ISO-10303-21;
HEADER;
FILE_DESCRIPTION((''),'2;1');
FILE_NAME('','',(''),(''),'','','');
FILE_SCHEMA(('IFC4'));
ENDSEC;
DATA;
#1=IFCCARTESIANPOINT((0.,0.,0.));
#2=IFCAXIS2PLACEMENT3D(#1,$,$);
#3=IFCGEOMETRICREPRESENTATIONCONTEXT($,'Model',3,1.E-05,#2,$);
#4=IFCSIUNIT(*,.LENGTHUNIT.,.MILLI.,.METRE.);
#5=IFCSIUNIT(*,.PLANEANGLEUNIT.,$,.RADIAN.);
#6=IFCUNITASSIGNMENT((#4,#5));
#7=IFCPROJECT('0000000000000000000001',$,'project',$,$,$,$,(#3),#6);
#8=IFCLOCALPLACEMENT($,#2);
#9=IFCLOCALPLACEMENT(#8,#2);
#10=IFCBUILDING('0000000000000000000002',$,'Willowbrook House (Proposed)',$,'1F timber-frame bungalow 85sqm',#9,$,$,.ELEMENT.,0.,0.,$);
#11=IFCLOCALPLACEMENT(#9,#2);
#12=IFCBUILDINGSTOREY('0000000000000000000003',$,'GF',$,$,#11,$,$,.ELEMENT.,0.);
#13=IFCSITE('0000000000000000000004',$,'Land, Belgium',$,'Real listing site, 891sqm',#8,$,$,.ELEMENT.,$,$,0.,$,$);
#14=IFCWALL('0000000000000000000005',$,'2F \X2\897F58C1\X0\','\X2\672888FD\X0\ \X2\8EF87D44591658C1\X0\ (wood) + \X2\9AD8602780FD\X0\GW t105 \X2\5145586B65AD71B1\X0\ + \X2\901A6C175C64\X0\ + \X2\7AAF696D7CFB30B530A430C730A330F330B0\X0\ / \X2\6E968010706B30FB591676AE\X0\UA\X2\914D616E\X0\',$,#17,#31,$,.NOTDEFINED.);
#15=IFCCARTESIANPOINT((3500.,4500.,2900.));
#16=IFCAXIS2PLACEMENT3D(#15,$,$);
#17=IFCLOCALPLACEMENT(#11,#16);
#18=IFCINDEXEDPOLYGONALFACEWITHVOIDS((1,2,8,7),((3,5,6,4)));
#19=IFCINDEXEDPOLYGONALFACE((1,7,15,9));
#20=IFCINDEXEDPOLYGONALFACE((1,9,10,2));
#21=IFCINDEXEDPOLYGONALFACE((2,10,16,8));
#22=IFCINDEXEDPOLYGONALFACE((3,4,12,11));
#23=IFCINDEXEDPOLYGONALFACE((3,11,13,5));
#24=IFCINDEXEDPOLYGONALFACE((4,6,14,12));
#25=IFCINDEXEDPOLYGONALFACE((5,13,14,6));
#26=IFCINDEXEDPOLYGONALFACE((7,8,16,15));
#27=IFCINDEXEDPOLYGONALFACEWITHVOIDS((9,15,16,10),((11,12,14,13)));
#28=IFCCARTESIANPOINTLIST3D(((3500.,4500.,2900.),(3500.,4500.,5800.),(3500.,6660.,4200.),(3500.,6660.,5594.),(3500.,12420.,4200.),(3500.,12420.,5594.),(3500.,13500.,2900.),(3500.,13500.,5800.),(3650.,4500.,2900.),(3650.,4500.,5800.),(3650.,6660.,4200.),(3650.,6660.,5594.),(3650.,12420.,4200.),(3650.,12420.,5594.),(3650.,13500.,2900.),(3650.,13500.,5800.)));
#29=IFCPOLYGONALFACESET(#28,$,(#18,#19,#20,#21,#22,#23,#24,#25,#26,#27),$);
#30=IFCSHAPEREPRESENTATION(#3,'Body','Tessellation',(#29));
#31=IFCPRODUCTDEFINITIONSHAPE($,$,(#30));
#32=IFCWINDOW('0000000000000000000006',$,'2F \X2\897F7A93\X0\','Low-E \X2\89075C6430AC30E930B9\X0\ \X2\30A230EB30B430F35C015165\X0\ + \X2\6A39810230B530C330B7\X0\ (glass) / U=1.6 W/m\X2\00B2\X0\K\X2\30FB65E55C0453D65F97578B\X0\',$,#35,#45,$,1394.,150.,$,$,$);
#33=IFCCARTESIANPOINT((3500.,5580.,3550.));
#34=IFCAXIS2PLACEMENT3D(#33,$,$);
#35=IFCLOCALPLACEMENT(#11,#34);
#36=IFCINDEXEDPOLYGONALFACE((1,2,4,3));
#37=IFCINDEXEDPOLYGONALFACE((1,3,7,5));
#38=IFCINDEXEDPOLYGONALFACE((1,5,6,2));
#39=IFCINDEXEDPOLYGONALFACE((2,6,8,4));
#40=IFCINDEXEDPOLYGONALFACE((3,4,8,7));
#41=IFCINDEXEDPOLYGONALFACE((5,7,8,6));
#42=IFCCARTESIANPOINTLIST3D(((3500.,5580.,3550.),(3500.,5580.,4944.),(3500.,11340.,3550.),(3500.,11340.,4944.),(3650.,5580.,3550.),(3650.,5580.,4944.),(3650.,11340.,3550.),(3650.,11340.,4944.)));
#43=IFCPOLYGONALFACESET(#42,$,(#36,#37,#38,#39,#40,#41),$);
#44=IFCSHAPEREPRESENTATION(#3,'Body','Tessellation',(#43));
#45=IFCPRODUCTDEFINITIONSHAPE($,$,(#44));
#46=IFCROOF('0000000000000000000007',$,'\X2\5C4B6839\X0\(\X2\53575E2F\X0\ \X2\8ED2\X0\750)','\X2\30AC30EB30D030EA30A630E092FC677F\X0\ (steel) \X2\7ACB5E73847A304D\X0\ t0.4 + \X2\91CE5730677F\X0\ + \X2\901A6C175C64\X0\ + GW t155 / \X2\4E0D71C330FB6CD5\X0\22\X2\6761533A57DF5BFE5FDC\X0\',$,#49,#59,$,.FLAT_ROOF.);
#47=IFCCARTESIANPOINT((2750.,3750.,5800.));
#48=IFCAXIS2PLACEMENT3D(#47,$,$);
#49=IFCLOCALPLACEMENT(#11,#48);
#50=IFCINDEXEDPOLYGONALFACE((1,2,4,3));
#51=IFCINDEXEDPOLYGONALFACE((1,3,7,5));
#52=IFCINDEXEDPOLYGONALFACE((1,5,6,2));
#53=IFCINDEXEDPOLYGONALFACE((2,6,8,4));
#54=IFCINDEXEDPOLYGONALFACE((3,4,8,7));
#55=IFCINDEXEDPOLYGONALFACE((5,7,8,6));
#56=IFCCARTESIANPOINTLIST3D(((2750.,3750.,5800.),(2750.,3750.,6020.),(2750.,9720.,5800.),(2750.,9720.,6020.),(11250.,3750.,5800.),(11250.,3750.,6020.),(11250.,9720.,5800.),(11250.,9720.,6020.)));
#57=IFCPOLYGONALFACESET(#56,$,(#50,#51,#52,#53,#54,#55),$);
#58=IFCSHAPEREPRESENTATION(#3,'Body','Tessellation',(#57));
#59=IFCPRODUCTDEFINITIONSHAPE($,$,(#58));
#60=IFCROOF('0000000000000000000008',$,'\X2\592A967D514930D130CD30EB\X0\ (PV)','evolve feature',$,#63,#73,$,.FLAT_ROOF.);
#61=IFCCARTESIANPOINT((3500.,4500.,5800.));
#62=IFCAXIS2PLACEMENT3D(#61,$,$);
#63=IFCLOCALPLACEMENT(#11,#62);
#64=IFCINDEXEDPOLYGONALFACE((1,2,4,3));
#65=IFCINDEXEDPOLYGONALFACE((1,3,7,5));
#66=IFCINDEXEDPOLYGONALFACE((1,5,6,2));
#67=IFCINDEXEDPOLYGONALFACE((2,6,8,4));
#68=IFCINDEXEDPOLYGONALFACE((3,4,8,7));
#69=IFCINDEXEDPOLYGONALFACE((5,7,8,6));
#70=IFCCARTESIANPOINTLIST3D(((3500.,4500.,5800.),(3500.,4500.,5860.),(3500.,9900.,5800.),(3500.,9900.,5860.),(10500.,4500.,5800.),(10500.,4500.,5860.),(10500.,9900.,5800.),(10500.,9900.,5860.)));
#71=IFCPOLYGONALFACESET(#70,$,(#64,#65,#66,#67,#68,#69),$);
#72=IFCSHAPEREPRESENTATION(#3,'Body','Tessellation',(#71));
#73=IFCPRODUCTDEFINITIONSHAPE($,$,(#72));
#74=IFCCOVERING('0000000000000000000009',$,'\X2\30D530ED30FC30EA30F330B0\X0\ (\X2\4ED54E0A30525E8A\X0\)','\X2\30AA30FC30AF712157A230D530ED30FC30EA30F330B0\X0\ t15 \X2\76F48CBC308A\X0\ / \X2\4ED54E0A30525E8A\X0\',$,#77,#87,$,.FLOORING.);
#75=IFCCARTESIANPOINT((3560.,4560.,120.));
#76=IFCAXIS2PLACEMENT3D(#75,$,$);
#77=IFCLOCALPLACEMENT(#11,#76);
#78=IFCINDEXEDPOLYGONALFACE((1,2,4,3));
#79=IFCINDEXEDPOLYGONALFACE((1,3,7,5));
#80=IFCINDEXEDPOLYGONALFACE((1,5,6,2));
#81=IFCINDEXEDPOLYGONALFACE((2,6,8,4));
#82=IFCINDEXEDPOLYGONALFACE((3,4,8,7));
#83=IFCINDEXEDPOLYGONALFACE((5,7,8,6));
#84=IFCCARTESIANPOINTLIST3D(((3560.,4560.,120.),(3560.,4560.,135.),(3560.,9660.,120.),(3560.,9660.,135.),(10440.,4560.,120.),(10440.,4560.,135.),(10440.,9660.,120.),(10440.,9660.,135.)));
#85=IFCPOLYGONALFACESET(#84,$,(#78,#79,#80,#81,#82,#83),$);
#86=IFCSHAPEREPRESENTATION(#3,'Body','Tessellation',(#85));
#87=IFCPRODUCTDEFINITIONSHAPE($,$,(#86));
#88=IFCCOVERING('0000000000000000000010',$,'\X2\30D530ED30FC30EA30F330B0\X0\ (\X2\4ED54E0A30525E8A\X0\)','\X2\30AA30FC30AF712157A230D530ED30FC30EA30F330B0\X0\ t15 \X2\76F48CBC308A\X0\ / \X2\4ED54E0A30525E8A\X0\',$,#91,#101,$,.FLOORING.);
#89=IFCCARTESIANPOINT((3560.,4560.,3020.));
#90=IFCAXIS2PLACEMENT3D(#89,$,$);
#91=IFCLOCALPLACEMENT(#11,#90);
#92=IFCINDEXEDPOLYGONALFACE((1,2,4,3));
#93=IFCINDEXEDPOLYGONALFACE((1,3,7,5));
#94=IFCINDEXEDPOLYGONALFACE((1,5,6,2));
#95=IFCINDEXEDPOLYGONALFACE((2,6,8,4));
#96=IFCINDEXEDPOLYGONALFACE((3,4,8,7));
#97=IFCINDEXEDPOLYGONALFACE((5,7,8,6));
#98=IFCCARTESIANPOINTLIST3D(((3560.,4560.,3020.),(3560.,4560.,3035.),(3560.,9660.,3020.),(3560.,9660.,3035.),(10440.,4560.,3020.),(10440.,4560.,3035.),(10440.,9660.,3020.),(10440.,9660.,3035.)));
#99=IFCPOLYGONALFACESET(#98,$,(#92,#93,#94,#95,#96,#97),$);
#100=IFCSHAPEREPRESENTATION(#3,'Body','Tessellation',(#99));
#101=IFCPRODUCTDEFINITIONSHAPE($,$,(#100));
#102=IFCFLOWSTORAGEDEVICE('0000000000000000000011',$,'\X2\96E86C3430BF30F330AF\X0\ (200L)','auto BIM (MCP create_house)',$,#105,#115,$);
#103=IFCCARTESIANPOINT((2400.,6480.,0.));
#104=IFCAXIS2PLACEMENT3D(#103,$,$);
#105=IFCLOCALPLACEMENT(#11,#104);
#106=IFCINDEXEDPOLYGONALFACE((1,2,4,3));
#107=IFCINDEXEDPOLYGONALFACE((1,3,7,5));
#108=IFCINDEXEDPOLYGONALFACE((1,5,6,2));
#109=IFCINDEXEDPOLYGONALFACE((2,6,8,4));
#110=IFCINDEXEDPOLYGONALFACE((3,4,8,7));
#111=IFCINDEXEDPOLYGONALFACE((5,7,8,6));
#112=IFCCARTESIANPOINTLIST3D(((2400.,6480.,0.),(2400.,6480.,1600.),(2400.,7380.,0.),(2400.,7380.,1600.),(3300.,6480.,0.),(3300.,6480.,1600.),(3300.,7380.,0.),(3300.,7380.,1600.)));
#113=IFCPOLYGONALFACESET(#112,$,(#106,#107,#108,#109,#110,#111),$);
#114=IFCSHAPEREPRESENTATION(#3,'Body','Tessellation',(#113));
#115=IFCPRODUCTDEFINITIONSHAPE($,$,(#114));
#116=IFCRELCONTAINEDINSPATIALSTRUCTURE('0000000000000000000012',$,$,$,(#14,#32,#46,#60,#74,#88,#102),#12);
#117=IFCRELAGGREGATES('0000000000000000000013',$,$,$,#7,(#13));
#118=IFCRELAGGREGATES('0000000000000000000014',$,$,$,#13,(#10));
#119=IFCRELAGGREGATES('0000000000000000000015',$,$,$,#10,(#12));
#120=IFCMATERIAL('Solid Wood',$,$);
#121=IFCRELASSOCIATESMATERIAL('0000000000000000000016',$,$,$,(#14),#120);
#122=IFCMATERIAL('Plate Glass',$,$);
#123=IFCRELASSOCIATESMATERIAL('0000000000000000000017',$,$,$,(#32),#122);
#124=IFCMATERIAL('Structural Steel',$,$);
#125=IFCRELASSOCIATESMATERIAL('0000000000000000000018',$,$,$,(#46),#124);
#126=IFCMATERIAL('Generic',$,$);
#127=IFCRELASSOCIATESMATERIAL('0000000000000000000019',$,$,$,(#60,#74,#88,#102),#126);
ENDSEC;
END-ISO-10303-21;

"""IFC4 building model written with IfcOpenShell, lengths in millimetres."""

from ifc_helpers import new_model, si_unit, frame, frame_2d, origin, place, context, project, spatial, rectangle, extrude, material, element, fill, save


model = new_model("IFC4")

# Units and contexts
model_context = context("Model", 3, precision=1e-05, world=origin())
ifc_project = project(units=[si_unit("LENGTHUNIT", "METRE", prefix="MILLI"), si_unit("PLANEANGLEUNIT", "RADIAN")], contexts=[model_context])

# Site, building, storey
site_placement = place(None, origin())
site = spatial("IfcSite", under=ifc_project, at=site_placement, Name="Land, Belgium", ObjectType="Real listing site, 891sqm", CompositionType="ELEMENT", RefElevation=0.0)
building_placement = place(site_placement, origin())
building = spatial("IfcBuilding", under=site, at=building_placement, Name="Willowbrook House (Proposed)", ObjectType="1F timber-frame bungalow 85sqm", CompositionType="ELEMENT", ElevationOfRefHeight=0.0, ElevationOfTerrain=0.0)
storey_placement = place(building_placement, origin())
storey = spatial("IfcBuildingStorey", under=building, at=storey_placement, Name="GF", CompositionType="ELEMENT", Elevation=0.0)

# Shared definitions
ifc_material_1 = material(Name="Solid Wood")
ifc_material_2 = material(Name="Generic")

# Shared definitions
ifc_material_3 = material(Name="Plate Glass")

# Wall, opening, window
wall_1_placement = place(storey_placement, frame((3500.0, 4500.0, 2900.0)))
wall_1 = element("IfcWall", 1, at=wall_1_placement, inside=storey, material=ifc_material_1, Name="2F 西壁", Description="木製 軸組外壁 (wood) + 高性能GW t105 充填断熱 + 通気層 + 窯業系サイディング / 準耐火・外皮UA配慮", PredefinedType="NOTDEFINED", context=model_context, shape_type="SweptSolid", body=[
    extrude(rectangle(XDim=150.0, YDim=9000.0, at=frame_2d((75.0, 4500.0))), frame((3500.0, 4500.0, 2900.0)), (0.0, 0.0, 1.0), 2900.0),
])
opening_1_placement = place(storey_placement, frame((3500.0, 5580.0, 3550.0)))
opening_1 = element("IfcOpeningElement", 2, at=opening_1_placement, cuts=wall_1, PredefinedType="NOTDEFINED", context=model_context, shape_type="SweptSolid", body=[
    extrude(rectangle(XDim=150.0, YDim=5760.0, at=frame_2d((75.0, 2880.0))), frame((3500.0, 5580.0, 3550.0)), (0.0, 0.0, 1.0), 1394.0),
])
window_1_placement = place(storey_placement, frame((3500.0, 5580.0, 3550.0)))
window_1 = element("IfcWindow", 3, at=window_1_placement, inside=storey, material=ifc_material_3, Name="2F 西窓", Description="Low-E 複層ガラス アルゴン封入 + 樹脂サッシ (glass) / U=1.6 W/m²K・日射取得型", OverallHeight=1394.0, OverallWidth=150.0, context=model_context, shape_type="SweptSolid", body=[
    extrude(rectangle(XDim=150.0, YDim=5760.0, at=frame_2d((75.0, 2880.0))), frame((3500.0, 5580.0, 3550.0)), (0.0, 0.0, 1.0), 1394.0),
])
fill(opening_1, window_1)

# Roofs
ifc_material_4 = material(Name="Structural Steel")
for number, where, name in (
    (4, (2750.0, 3750.0, 5800.0), "屋根(南帯 軒750)"),
):
    element("IfcRoof", number, at=place(storey_placement, frame(where)), inside=storey, material=ifc_material_4, Name=name, Description="ガルバリウム鋼板 (steel) 立平葺き t0.4 + 野地板 + 通気層 + GW t155 / 不燃・法22条区域対応", PredefinedType="FLAT_ROOF", context=model_context, shape_type="SweptSolid", body=[
        extrude(rectangle(XDim=8500.0, YDim=5970.0, at=frame_2d((4250.0, 2985.0))), frame((2750.0, 3750.0, 5800.0)), (0.0, 0.0, 1.0), 220.0),
    ])
roof_placement = place(storey_placement, frame((3500.0, 4500.0, 5800.0)))
element("IfcRoof", 5, at=roof_placement, inside=storey, material=ifc_material_2, Name="太陽光パネル (PV)", Description="evolve feature", PredefinedType="FLAT_ROOF", context=model_context, shape_type="SweptSolid", body=[
    extrude(rectangle(XDim=7000.0, YDim=5400.0, at=frame_2d((3500.0, 2700.0))), frame((3500.0, 4500.0, 5800.0)), (0.0, 0.0, 1.0), 60.0),
])

# Coverings
covering_1_placement = place(storey_placement, frame((3560.0, 4560.0, 120.0)))
element("IfcCovering", 6, at=covering_1_placement, inside=storey, material=ifc_material_2, Name="フローリング (仕上げ床)", Description="オーク無垢フローリング t15 直貼り / 仕上げ床", PredefinedType="FLOORING", context=model_context, shape_type="SweptSolid", body=[
    extrude(rectangle(XDim=6880.0, YDim=5100.0, at=frame_2d((3440.0, 2550.0))), frame((3560.0, 4560.0, 120.0)), (0.0, 0.0, 1.0), 15.0),
])
covering_2_placement = place(storey_placement, frame((3560.0, 4560.0, 3020.0)))
element("IfcCovering", 7, at=covering_2_placement, inside=storey, material=ifc_material_2, Name="フローリング (仕上げ床)", Description="オーク無垢フローリング t15 直貼り / 仕上げ床", PredefinedType="FLOORING", context=model_context, shape_type="SweptSolid", body=[
    extrude(rectangle(XDim=6880.0, YDim=5100.0, at=frame_2d((3440.0, 2550.0))), frame((3560.0, 4560.0, 3020.0)), (0.0, 0.0, 1.0), 15.0),
])

# Flow storage device
flow_storage_device_placement = place(storey_placement, frame((2400.0, 6480.0, 0.0)))
element("IfcFlowStorageDevice", 8, at=flow_storage_device_placement, inside=storey, material=ifc_material_2, Name="雨水タンク (200L)", Description="auto BIM (MCP create_house)", context=model_context, shape_type="SweptSolid", body=[
    extrude(rectangle(XDim=900.0, YDim=900.0, at=frame_2d((450.0, 450.0))), frame((2400.0, 6480.0, 0.0)), (0.0, 0.0, 1.0), 1600.0),
])

save(model, "model.ifc")
